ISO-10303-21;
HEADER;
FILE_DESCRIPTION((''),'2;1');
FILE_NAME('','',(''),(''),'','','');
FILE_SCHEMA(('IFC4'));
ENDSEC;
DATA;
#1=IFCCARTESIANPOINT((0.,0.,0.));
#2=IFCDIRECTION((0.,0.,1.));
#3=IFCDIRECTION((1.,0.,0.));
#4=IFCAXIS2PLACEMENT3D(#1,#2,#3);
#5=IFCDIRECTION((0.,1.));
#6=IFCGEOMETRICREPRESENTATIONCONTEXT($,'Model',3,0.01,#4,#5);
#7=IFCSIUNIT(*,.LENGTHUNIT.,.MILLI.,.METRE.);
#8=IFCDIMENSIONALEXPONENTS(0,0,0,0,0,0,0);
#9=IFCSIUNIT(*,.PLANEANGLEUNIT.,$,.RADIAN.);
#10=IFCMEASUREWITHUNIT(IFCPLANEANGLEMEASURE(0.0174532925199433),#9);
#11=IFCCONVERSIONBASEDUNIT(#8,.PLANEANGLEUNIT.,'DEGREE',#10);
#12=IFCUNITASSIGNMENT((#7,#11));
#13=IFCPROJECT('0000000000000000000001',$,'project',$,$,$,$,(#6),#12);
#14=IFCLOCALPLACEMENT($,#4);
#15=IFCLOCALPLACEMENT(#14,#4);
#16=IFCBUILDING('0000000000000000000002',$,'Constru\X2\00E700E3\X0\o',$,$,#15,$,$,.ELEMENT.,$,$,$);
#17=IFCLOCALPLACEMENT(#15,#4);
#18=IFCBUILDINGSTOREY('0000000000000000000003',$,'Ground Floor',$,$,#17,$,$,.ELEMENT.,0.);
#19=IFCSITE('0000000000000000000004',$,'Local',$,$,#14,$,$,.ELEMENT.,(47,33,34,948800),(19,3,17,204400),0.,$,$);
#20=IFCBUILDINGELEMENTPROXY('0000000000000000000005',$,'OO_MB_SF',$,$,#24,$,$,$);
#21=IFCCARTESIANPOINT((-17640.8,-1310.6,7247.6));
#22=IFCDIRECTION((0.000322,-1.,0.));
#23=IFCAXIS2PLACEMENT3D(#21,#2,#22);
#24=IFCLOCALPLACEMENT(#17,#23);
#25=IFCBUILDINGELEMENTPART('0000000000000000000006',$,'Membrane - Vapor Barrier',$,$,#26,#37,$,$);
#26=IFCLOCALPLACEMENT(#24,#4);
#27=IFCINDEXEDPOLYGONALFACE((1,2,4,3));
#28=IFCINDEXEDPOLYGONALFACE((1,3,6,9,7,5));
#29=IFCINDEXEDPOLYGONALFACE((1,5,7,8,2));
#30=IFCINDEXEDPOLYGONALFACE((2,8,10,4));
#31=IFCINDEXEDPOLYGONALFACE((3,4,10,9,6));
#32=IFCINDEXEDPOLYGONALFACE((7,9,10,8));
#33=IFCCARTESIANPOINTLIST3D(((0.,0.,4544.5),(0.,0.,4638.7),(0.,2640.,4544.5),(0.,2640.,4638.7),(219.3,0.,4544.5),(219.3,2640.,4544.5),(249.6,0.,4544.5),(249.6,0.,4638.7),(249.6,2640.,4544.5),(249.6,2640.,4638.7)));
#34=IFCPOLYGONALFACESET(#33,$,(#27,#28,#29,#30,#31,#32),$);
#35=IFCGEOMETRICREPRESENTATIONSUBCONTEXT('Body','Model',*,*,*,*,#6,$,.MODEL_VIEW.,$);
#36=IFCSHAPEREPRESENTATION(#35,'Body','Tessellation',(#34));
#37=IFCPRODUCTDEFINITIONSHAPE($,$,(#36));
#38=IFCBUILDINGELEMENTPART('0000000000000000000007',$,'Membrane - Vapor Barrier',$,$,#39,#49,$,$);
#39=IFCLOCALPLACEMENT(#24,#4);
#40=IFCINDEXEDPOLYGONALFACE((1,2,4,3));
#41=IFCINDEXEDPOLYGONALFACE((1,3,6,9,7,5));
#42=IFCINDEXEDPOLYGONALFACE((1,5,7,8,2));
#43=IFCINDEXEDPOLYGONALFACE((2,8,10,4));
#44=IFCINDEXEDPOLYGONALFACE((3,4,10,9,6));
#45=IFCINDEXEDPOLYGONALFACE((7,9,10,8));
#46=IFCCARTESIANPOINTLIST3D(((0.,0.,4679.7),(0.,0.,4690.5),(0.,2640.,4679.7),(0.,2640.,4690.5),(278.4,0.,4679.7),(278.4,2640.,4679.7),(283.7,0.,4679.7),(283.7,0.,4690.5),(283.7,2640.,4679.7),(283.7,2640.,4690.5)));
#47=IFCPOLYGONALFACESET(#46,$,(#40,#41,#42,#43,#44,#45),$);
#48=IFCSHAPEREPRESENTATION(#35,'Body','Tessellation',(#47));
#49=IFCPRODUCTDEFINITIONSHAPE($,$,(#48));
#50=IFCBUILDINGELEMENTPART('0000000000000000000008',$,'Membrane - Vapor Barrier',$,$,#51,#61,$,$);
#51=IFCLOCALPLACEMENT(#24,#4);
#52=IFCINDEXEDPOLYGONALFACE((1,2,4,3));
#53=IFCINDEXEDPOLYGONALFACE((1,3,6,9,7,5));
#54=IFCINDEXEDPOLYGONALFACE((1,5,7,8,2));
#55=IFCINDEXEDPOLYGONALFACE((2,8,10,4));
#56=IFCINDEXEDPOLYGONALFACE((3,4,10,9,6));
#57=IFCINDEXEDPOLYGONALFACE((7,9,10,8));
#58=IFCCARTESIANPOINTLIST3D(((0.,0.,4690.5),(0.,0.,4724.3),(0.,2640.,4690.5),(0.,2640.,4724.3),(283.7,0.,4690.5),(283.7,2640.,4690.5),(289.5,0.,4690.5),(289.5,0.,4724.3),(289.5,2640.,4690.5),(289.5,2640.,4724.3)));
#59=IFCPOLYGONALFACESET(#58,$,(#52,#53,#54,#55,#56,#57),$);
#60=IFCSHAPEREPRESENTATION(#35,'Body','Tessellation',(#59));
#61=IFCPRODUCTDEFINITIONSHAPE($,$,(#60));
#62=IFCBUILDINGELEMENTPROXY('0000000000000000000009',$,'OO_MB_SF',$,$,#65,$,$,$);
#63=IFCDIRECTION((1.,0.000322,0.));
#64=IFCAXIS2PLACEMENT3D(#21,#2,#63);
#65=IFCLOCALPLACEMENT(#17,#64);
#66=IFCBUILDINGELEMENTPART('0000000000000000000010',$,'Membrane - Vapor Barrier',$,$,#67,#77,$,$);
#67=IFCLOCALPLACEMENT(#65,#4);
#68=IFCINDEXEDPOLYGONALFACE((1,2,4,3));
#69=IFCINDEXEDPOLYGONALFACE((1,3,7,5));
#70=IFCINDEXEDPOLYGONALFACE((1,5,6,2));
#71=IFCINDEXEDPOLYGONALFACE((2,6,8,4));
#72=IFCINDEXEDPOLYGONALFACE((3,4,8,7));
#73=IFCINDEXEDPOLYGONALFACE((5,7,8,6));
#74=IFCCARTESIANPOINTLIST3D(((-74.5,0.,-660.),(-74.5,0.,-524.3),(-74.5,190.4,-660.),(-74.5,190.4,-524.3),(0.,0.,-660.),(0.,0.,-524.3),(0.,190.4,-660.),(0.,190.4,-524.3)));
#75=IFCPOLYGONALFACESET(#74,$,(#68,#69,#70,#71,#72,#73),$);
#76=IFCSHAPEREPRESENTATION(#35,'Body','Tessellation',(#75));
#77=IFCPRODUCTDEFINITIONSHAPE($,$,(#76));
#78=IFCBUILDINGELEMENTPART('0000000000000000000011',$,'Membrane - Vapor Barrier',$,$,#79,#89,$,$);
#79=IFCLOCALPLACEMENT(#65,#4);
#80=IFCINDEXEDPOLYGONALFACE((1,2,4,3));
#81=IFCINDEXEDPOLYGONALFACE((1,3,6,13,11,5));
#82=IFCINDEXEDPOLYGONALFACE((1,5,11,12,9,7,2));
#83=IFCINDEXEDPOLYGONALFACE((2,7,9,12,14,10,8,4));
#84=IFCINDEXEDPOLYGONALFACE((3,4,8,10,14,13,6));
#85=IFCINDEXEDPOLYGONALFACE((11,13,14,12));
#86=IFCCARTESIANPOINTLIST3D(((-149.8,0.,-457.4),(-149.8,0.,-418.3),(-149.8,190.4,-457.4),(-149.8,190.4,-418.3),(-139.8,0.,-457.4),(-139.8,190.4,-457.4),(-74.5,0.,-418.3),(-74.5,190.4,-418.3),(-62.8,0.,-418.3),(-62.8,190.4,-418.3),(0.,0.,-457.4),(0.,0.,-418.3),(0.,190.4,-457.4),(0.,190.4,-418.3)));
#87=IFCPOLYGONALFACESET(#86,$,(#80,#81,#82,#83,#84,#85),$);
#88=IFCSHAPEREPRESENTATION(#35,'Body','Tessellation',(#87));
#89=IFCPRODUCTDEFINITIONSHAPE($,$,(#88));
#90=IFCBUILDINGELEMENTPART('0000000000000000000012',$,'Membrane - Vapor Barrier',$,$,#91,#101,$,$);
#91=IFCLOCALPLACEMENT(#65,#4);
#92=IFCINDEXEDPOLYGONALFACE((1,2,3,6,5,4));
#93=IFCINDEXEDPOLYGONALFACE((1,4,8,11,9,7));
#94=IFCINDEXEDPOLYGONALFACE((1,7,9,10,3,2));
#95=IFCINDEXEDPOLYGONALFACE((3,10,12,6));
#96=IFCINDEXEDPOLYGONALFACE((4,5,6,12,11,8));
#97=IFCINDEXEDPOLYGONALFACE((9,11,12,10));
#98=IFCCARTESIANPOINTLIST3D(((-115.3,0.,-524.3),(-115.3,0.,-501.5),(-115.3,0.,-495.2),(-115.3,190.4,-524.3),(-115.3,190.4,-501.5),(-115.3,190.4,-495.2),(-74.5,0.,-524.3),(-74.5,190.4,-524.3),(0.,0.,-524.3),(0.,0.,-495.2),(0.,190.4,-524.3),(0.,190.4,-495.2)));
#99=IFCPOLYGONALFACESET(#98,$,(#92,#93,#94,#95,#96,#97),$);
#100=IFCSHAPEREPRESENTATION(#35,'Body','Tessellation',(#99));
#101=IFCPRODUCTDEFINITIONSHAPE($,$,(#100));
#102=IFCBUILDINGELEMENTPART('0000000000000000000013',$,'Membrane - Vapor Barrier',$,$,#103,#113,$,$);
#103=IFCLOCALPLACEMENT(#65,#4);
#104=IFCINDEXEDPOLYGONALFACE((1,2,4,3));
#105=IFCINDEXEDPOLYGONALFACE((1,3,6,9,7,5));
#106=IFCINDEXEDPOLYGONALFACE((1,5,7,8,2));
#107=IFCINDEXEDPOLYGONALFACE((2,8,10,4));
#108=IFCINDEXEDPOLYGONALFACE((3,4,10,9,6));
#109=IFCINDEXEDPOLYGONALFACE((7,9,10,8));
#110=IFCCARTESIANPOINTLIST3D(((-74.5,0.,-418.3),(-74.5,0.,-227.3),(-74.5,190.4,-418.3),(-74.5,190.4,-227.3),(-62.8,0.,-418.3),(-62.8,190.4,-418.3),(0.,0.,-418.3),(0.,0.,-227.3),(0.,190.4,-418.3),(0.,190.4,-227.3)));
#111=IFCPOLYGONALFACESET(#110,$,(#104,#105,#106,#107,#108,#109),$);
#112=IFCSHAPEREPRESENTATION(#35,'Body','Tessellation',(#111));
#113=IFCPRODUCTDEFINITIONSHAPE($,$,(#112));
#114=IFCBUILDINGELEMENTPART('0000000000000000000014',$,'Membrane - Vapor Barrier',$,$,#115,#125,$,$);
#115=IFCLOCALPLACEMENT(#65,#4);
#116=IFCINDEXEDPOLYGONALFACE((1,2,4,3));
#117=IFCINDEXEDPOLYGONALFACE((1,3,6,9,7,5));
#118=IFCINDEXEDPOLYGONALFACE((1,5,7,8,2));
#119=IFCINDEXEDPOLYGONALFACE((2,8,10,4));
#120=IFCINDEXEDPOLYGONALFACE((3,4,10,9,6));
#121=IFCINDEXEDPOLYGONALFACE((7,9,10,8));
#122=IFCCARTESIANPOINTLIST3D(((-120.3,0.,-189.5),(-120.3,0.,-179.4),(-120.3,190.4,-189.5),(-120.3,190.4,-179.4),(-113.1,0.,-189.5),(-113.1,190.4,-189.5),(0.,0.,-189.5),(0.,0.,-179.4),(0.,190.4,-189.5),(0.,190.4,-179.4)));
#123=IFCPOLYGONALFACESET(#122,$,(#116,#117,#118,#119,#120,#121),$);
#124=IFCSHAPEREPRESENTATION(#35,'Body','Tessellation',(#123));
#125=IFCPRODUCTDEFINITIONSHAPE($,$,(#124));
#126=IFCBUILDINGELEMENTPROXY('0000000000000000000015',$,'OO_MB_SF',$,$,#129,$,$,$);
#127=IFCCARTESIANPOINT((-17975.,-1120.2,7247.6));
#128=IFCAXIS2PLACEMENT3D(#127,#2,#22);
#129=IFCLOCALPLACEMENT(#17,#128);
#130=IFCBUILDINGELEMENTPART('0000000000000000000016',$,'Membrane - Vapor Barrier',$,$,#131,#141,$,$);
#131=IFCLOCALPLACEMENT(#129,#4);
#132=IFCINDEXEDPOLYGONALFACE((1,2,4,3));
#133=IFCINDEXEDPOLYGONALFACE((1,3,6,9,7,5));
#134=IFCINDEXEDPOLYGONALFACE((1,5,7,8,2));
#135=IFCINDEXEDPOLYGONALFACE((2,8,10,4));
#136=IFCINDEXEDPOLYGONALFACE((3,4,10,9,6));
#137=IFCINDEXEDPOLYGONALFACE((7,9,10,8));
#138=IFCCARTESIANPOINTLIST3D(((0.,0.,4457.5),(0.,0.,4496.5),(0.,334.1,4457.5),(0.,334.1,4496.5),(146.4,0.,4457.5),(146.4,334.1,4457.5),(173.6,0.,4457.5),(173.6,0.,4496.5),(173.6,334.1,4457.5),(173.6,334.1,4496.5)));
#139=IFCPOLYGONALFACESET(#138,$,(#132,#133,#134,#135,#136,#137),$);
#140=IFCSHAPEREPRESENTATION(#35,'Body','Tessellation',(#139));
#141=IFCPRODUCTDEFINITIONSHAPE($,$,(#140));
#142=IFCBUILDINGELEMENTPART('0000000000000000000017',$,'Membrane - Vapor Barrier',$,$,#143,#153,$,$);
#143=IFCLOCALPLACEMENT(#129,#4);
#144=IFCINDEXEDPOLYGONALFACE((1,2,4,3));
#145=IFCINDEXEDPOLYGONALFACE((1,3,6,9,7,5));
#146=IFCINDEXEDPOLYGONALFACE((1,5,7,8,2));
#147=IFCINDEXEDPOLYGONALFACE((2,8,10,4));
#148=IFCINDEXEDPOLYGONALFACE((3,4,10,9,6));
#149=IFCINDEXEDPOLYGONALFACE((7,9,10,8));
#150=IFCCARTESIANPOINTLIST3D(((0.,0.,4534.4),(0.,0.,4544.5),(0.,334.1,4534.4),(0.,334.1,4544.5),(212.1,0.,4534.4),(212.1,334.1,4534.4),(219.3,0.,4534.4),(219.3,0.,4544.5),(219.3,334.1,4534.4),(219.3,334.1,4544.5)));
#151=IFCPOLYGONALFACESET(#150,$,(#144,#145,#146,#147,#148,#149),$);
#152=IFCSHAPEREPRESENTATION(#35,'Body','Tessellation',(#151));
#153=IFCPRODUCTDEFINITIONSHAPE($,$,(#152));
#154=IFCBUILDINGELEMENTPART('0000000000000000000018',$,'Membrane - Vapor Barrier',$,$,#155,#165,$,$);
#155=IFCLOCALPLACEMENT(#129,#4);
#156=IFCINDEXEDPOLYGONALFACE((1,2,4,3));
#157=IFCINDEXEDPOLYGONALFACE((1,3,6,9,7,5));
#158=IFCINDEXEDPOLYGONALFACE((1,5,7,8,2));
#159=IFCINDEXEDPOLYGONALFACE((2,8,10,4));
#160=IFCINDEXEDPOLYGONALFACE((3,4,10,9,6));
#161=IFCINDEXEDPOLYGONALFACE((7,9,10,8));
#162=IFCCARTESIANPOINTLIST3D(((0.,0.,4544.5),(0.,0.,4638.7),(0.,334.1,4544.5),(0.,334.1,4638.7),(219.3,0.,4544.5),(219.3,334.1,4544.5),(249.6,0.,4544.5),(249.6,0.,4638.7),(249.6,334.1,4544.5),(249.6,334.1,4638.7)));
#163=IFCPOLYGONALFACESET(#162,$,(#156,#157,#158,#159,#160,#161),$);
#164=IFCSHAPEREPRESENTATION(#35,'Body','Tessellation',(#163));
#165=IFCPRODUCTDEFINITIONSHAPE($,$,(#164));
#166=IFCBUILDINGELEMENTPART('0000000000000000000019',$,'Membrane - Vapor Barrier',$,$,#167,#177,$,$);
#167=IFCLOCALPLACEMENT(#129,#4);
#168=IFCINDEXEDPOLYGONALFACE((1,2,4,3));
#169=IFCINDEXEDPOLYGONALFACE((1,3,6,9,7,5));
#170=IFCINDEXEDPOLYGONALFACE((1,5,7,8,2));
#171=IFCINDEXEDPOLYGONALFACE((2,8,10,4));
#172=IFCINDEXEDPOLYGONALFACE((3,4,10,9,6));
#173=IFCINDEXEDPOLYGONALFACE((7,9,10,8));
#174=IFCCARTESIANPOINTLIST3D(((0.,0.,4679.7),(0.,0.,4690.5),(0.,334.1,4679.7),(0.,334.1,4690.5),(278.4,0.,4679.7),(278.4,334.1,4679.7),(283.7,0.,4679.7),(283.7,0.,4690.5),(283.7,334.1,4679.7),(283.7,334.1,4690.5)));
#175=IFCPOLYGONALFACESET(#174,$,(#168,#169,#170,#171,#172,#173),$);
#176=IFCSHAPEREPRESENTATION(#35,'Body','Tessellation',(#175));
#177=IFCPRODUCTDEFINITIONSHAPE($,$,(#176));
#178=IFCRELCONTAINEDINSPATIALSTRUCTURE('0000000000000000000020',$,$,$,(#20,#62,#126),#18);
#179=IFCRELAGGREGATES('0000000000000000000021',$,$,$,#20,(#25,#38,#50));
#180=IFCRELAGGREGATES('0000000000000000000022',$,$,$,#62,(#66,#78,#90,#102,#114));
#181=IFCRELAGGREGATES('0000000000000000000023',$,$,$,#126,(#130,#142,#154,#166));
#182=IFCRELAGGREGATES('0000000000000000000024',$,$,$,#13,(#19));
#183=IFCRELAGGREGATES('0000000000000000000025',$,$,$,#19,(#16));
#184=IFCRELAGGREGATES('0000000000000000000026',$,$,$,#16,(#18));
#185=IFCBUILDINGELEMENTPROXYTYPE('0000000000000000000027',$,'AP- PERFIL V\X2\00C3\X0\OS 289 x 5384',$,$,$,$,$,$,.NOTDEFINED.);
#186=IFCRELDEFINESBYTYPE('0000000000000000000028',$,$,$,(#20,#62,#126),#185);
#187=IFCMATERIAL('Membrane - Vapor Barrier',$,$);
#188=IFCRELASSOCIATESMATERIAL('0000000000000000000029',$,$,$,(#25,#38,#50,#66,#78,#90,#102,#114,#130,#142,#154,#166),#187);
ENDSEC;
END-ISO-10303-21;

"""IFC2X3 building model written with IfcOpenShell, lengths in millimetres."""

from ifc_helpers import new_model, entity, si_unit, converted_unit, direction, frame, origin_with_axes, place, context, subcontext, project, spatial, polyline, outline, extrude, material, type_object, element, aggregate, save


model = new_model("IFC2X3")

# Units and contexts
model_context = context("Model", 3, precision=0.01, world=origin_with_axes(), true_north=direction((0.0, 1.0)))
body_context = subcontext(model_context, "Body", "Model", "MODEL_VIEW")
ifc_project = project(units=[si_unit("LENGTHUNIT", "METRE", prefix="MILLI"), converted_unit("PLANEANGLEUNIT", "DEGREE", entity("IfcPlaneAngleMeasure", 0.0174532925199433), si_unit("PLANEANGLEUNIT", "RADIAN"), dimensions=[0, 0, 0, 0, 0, 0, 0])], contexts=[model_context])

# Site, building, storey
site_placement = place(None, origin_with_axes())
site = spatial("IfcSite", under=ifc_project, at=site_placement, Name="Local", CompositionType="ELEMENT", RefLatitude=(47, 33, 34, 948800), RefLongitude=(19, 3, 17, 204400), RefElevation=0.0)
building_placement = place(site_placement, origin_with_axes())
building = spatial("IfcBuilding", under=site, at=building_placement, Name="Construção", CompositionType="ELEMENT")
storey_placement = place(building_placement, origin_with_axes())
storey = spatial("IfcBuildingStorey", under=building, at=storey_placement, Name="Ground Floor", CompositionType="ELEMENT", Elevation=0.0)

# Building element proxies, building element parts
building_element_proxy_type = type_object("IfcBuildingElementProxyType", Name="AP- PERFIL VÃOS 289 x 5384", PredefinedType="NOTDEFINED")
proxy_1_placement = place(storey_placement, frame((-17640.8, -1310.6, 7247.6), z_axis=(0.0, 0.0, 1.0), x_axis=(0.000322, -1.0, 0.0)))
proxy_1 = element("IfcBuildingElementProxy", 1, at=proxy_1_placement, inside=storey, type_object=building_element_proxy_type, Name="OO_MB_SF")
ifc_material = material(Name="Membrane - Vapor Barrier")
building_element_part_1_placement = place(proxy_1_placement, origin_with_axes())
building_element_part_1 = element("IfcBuildingElementPart", 2, at=building_element_part_1_placement, material=ifc_material, Name="Membrane - Vapor Barrier", context=body_context, shape_type="SweptSolid", body=[
    extrude(outline(polyline([(249.6, 4638.7), (0.0, 4638.7), (0.0, 4544.5), (219.3, 4544.5), (249.6, 4544.5), (249.6, 4638.7)])), frame((0.0, 2640.0, 0.0), z_axis=(0.0, -1.0, 0.0), x_axis=(1.0, 0.0, 0.0)), (0.0, 0.0, 1.0), 2640.0),
])
building_element_part_2_placement = place(proxy_1_placement, origin_with_axes())
building_element_part_2 = element("IfcBuildingElementPart", 3, at=building_element_part_2_placement, material=ifc_material, Name="Membrane - Vapor Barrier", context=body_context, shape_type="SweptSolid", body=[
    extrude(outline(polyline([(0.0, 4679.7), (278.4, 4679.7), (283.7, 4679.7), (283.7, 4690.5), (0.0, 4690.5), (0.0, 4679.7)])), frame((0.0, 2640.0, 0.0), z_axis=(0.0, -1.0, 0.0), x_axis=(1.0, 0.0, 0.0)), (0.0, 0.0, 1.0), 2640.0),
])
building_element_part_3_placement = place(proxy_1_placement, origin_with_axes())
building_element_part_3 = element("IfcBuildingElementPart", 4, at=building_element_part_3_placement, material=ifc_material, Name="Membrane - Vapor Barrier", context=body_context, shape_type="SweptSolid", body=[
    extrude(outline(polyline([(0.0, 4690.5), (283.7, 4690.5), (289.5, 4690.5), (289.5, 4724.3), (0.0, 4724.3), (0.0, 4690.5)])), frame((0.0, 2640.0, 0.0), z_axis=(0.0, -1.0, 0.0), x_axis=(1.0, 0.0, 0.0)), (0.0, 0.0, 1.0), 2640.0),
])
aggregate(proxy_1, [building_element_part_1, building_element_part_2, building_element_part_3])
proxy_2_placement = place(storey_placement, frame((-17640.8, -1310.6, 7247.6), z_axis=(0.0, 0.0, 1.0), x_axis=(1.0, 0.000322, 0.0)))
proxy_2 = element("IfcBuildingElementProxy", 5, at=proxy_2_placement, inside=storey, type_object=building_element_proxy_type, Name="OO_MB_SF")
building_element_part_4_placement = place(proxy_2_placement, origin_with_axes())
building_element_part_4 = element("IfcBuildingElementPart", 6, at=building_element_part_4_placement, material=ifc_material, Name="Membrane - Vapor Barrier", context=body_context, shape_type="SweptSolid", body=[
    extrude(outline(polyline([(0.0, -660.0), (74.5, -660.0), (74.5, -524.3), (0.0, -524.3), (0.0, -660.0)])), frame((0.0, 190.4, 0.0), z_axis=(0.0, 1.0, 0.0), x_axis=(-1.0, 0.0, 0.0)), (0.0, 0.0, -1.0), 190.4),
])
building_element_part_5_placement = place(proxy_2_placement, origin_with_axes())
building_element_part_5 = element("IfcBuildingElementPart", 7, at=building_element_part_5_placement, material=ifc_material, Name="Membrane - Vapor Barrier", context=body_context, shape_type="SweptSolid", body=[
    extrude(outline(polyline([(62.8, -418.3), (0.0, -418.3), (0.0, -457.4), (139.8, -457.4), (149.8, -457.4), (149.8, -418.3), (74.5, -418.3), (62.8, -418.3)])), frame((0.0, 190.4, 0.0), z_axis=(0.0, 1.0, 0.0), x_axis=(-1.0, 0.0, 0.0)), (0.0, 0.0, -1.0), 190.4),
])
building_element_part_6_placement = place(proxy_2_placement, origin_with_axes())
building_element_part_6 = element("IfcBuildingElementPart", 8, at=building_element_part_6_placement, material=ifc_material, Name="Membrane - Vapor Barrier", context=body_context, shape_type="SweptSolid", body=[
    extrude(outline(polyline([(0.0, -524.3), (74.5, -524.3), (115.3, -524.3), (115.3, -501.5), (115.3, -495.2), (0.0, -495.2), (0.0, -524.3)])), frame((0.0, 190.4, 0.0), z_axis=(0.0, 1.0, 0.0), x_axis=(-1.0, 0.0, 0.0)), (0.0, 0.0, -1.0), 190.4),
])
building_element_part_7_placement = place(proxy_2_placement, origin_with_axes())
building_element_part_7 = element("IfcBuildingElementPart", 9, at=building_element_part_7_placement, material=ifc_material, Name="Membrane - Vapor Barrier", context=body_context, shape_type="SweptSolid", body=[
    extrude(outline(polyline([(0.0, -227.3), (0.0, -418.3), (62.8, -418.3), (74.5, -418.3), (74.5, -227.3), (0.0, -227.3)])), frame((0.0, 190.4, 0.0), z_axis=(0.0, 1.0, 0.0), x_axis=(-1.0, 0.0, 0.0)), (0.0, 0.0, -1.0), 190.4),
])
building_element_part_8_placement = place(proxy_2_placement, origin_with_axes())
building_element_part_8 = element("IfcBuildingElementPart", 10, at=building_element_part_8_placement, material=ifc_material, Name="Membrane - Vapor Barrier", context=body_context, shape_type="SweptSolid", body=[
    extrude(outline(polyline([(120.3, -179.4), (0.0, -179.4), (0.0, -189.5), (113.1, -189.5), (120.3, -189.5), (120.3, -179.4)])), frame((0.0, 190.4, 0.0), z_axis=(0.0, 1.0, 0.0), x_axis=(-1.0, 0.0, 0.0)), (0.0, 0.0, -1.0), 190.4),
])
aggregate(proxy_2, [building_element_part_4, building_element_part_5, building_element_part_6, building_element_part_7, building_element_part_8])
proxy_3_placement = place(storey_placement, frame((-17975.0, -1120.2, 7247.6), z_axis=(0.0, 0.0, 1.0), x_axis=(0.000322, -1.0, 0.0)))
proxy_3 = element("IfcBuildingElementProxy", 11, at=proxy_3_placement, inside=storey, type_object=building_element_proxy_type, Name="OO_MB_SF")
building_element_part_9_placement = place(proxy_3_placement, origin_with_axes())
building_element_part_9 = element("IfcBuildingElementPart", 12, at=building_element_part_9_placement, material=ifc_material, Name="Membrane - Vapor Barrier", context=body_context, shape_type="SweptSolid", body=[
    extrude(outline(polyline([(173.6, 4496.5), (0.0, 4496.5), (0.0, 4457.5), (146.4, 4457.5), (173.6, 4457.5), (173.6, 4496.5)])), frame((0.0, 334.1, 0.0), z_axis=(0.0, -1.0, 0.0), x_axis=(1.0, 0.0, 0.0)), (0.0, 0.0, 1.0), 334.1),
])
building_element_part_10_placement = place(proxy_3_placement, origin_with_axes())
building_element_part_10 = element("IfcBuildingElementPart", 13, at=building_element_part_10_placement, material=ifc_material, Name="Membrane - Vapor Barrier", context=body_context, shape_type="SweptSolid", body=[
    extrude(outline(polyline([(0.0, 4534.4), (212.1, 4534.4), (219.3, 4534.4), (219.3, 4544.5), (0.0, 4544.5), (0.0, 4534.4)])), frame((0.0, 334.1, 0.0), z_axis=(0.0, -1.0, 0.0), x_axis=(1.0, 0.0, 0.0)), (0.0, 0.0, 1.0), 334.1),
])
building_element_part_11_placement = place(proxy_3_placement, origin_with_axes())
building_element_part_11 = element("IfcBuildingElementPart", 14, at=building_element_part_11_placement, material=ifc_material, Name="Membrane - Vapor Barrier", context=body_context, shape_type="SweptSolid", body=[
    extrude(outline(polyline([(249.6, 4638.7), (0.0, 4638.7), (0.0, 4544.5), (219.3, 4544.5), (249.6, 4544.5), (249.6, 4638.7)])), frame((0.0, 334.1, 0.0), z_axis=(0.0, -1.0, 0.0), x_axis=(1.0, 0.0, 0.0)), (0.0, 0.0, 1.0), 334.1),
])
building_element_part_12_placement = place(proxy_3_placement, origin_with_axes())
building_element_part_12 = element("IfcBuildingElementPart", 15, at=building_element_part_12_placement, material=ifc_material, Name="Membrane - Vapor Barrier", context=body_context, shape_type="SweptSolid", body=[
    extrude(outline(polyline([(0.0, 4679.7), (278.4, 4679.7), (283.7, 4679.7), (283.7, 4690.5), (0.0, 4690.5), (0.0, 4679.7)])), frame((0.0, 334.1, 0.0), z_axis=(0.0, -1.0, 0.0), x_axis=(1.0, 0.0, 0.0)), (0.0, 0.0, 1.0), 334.1),
])
aggregate(proxy_3, [building_element_part_9, building_element_part_10, building_element_part_11, building_element_part_12])

save(model, "model.ifc")
